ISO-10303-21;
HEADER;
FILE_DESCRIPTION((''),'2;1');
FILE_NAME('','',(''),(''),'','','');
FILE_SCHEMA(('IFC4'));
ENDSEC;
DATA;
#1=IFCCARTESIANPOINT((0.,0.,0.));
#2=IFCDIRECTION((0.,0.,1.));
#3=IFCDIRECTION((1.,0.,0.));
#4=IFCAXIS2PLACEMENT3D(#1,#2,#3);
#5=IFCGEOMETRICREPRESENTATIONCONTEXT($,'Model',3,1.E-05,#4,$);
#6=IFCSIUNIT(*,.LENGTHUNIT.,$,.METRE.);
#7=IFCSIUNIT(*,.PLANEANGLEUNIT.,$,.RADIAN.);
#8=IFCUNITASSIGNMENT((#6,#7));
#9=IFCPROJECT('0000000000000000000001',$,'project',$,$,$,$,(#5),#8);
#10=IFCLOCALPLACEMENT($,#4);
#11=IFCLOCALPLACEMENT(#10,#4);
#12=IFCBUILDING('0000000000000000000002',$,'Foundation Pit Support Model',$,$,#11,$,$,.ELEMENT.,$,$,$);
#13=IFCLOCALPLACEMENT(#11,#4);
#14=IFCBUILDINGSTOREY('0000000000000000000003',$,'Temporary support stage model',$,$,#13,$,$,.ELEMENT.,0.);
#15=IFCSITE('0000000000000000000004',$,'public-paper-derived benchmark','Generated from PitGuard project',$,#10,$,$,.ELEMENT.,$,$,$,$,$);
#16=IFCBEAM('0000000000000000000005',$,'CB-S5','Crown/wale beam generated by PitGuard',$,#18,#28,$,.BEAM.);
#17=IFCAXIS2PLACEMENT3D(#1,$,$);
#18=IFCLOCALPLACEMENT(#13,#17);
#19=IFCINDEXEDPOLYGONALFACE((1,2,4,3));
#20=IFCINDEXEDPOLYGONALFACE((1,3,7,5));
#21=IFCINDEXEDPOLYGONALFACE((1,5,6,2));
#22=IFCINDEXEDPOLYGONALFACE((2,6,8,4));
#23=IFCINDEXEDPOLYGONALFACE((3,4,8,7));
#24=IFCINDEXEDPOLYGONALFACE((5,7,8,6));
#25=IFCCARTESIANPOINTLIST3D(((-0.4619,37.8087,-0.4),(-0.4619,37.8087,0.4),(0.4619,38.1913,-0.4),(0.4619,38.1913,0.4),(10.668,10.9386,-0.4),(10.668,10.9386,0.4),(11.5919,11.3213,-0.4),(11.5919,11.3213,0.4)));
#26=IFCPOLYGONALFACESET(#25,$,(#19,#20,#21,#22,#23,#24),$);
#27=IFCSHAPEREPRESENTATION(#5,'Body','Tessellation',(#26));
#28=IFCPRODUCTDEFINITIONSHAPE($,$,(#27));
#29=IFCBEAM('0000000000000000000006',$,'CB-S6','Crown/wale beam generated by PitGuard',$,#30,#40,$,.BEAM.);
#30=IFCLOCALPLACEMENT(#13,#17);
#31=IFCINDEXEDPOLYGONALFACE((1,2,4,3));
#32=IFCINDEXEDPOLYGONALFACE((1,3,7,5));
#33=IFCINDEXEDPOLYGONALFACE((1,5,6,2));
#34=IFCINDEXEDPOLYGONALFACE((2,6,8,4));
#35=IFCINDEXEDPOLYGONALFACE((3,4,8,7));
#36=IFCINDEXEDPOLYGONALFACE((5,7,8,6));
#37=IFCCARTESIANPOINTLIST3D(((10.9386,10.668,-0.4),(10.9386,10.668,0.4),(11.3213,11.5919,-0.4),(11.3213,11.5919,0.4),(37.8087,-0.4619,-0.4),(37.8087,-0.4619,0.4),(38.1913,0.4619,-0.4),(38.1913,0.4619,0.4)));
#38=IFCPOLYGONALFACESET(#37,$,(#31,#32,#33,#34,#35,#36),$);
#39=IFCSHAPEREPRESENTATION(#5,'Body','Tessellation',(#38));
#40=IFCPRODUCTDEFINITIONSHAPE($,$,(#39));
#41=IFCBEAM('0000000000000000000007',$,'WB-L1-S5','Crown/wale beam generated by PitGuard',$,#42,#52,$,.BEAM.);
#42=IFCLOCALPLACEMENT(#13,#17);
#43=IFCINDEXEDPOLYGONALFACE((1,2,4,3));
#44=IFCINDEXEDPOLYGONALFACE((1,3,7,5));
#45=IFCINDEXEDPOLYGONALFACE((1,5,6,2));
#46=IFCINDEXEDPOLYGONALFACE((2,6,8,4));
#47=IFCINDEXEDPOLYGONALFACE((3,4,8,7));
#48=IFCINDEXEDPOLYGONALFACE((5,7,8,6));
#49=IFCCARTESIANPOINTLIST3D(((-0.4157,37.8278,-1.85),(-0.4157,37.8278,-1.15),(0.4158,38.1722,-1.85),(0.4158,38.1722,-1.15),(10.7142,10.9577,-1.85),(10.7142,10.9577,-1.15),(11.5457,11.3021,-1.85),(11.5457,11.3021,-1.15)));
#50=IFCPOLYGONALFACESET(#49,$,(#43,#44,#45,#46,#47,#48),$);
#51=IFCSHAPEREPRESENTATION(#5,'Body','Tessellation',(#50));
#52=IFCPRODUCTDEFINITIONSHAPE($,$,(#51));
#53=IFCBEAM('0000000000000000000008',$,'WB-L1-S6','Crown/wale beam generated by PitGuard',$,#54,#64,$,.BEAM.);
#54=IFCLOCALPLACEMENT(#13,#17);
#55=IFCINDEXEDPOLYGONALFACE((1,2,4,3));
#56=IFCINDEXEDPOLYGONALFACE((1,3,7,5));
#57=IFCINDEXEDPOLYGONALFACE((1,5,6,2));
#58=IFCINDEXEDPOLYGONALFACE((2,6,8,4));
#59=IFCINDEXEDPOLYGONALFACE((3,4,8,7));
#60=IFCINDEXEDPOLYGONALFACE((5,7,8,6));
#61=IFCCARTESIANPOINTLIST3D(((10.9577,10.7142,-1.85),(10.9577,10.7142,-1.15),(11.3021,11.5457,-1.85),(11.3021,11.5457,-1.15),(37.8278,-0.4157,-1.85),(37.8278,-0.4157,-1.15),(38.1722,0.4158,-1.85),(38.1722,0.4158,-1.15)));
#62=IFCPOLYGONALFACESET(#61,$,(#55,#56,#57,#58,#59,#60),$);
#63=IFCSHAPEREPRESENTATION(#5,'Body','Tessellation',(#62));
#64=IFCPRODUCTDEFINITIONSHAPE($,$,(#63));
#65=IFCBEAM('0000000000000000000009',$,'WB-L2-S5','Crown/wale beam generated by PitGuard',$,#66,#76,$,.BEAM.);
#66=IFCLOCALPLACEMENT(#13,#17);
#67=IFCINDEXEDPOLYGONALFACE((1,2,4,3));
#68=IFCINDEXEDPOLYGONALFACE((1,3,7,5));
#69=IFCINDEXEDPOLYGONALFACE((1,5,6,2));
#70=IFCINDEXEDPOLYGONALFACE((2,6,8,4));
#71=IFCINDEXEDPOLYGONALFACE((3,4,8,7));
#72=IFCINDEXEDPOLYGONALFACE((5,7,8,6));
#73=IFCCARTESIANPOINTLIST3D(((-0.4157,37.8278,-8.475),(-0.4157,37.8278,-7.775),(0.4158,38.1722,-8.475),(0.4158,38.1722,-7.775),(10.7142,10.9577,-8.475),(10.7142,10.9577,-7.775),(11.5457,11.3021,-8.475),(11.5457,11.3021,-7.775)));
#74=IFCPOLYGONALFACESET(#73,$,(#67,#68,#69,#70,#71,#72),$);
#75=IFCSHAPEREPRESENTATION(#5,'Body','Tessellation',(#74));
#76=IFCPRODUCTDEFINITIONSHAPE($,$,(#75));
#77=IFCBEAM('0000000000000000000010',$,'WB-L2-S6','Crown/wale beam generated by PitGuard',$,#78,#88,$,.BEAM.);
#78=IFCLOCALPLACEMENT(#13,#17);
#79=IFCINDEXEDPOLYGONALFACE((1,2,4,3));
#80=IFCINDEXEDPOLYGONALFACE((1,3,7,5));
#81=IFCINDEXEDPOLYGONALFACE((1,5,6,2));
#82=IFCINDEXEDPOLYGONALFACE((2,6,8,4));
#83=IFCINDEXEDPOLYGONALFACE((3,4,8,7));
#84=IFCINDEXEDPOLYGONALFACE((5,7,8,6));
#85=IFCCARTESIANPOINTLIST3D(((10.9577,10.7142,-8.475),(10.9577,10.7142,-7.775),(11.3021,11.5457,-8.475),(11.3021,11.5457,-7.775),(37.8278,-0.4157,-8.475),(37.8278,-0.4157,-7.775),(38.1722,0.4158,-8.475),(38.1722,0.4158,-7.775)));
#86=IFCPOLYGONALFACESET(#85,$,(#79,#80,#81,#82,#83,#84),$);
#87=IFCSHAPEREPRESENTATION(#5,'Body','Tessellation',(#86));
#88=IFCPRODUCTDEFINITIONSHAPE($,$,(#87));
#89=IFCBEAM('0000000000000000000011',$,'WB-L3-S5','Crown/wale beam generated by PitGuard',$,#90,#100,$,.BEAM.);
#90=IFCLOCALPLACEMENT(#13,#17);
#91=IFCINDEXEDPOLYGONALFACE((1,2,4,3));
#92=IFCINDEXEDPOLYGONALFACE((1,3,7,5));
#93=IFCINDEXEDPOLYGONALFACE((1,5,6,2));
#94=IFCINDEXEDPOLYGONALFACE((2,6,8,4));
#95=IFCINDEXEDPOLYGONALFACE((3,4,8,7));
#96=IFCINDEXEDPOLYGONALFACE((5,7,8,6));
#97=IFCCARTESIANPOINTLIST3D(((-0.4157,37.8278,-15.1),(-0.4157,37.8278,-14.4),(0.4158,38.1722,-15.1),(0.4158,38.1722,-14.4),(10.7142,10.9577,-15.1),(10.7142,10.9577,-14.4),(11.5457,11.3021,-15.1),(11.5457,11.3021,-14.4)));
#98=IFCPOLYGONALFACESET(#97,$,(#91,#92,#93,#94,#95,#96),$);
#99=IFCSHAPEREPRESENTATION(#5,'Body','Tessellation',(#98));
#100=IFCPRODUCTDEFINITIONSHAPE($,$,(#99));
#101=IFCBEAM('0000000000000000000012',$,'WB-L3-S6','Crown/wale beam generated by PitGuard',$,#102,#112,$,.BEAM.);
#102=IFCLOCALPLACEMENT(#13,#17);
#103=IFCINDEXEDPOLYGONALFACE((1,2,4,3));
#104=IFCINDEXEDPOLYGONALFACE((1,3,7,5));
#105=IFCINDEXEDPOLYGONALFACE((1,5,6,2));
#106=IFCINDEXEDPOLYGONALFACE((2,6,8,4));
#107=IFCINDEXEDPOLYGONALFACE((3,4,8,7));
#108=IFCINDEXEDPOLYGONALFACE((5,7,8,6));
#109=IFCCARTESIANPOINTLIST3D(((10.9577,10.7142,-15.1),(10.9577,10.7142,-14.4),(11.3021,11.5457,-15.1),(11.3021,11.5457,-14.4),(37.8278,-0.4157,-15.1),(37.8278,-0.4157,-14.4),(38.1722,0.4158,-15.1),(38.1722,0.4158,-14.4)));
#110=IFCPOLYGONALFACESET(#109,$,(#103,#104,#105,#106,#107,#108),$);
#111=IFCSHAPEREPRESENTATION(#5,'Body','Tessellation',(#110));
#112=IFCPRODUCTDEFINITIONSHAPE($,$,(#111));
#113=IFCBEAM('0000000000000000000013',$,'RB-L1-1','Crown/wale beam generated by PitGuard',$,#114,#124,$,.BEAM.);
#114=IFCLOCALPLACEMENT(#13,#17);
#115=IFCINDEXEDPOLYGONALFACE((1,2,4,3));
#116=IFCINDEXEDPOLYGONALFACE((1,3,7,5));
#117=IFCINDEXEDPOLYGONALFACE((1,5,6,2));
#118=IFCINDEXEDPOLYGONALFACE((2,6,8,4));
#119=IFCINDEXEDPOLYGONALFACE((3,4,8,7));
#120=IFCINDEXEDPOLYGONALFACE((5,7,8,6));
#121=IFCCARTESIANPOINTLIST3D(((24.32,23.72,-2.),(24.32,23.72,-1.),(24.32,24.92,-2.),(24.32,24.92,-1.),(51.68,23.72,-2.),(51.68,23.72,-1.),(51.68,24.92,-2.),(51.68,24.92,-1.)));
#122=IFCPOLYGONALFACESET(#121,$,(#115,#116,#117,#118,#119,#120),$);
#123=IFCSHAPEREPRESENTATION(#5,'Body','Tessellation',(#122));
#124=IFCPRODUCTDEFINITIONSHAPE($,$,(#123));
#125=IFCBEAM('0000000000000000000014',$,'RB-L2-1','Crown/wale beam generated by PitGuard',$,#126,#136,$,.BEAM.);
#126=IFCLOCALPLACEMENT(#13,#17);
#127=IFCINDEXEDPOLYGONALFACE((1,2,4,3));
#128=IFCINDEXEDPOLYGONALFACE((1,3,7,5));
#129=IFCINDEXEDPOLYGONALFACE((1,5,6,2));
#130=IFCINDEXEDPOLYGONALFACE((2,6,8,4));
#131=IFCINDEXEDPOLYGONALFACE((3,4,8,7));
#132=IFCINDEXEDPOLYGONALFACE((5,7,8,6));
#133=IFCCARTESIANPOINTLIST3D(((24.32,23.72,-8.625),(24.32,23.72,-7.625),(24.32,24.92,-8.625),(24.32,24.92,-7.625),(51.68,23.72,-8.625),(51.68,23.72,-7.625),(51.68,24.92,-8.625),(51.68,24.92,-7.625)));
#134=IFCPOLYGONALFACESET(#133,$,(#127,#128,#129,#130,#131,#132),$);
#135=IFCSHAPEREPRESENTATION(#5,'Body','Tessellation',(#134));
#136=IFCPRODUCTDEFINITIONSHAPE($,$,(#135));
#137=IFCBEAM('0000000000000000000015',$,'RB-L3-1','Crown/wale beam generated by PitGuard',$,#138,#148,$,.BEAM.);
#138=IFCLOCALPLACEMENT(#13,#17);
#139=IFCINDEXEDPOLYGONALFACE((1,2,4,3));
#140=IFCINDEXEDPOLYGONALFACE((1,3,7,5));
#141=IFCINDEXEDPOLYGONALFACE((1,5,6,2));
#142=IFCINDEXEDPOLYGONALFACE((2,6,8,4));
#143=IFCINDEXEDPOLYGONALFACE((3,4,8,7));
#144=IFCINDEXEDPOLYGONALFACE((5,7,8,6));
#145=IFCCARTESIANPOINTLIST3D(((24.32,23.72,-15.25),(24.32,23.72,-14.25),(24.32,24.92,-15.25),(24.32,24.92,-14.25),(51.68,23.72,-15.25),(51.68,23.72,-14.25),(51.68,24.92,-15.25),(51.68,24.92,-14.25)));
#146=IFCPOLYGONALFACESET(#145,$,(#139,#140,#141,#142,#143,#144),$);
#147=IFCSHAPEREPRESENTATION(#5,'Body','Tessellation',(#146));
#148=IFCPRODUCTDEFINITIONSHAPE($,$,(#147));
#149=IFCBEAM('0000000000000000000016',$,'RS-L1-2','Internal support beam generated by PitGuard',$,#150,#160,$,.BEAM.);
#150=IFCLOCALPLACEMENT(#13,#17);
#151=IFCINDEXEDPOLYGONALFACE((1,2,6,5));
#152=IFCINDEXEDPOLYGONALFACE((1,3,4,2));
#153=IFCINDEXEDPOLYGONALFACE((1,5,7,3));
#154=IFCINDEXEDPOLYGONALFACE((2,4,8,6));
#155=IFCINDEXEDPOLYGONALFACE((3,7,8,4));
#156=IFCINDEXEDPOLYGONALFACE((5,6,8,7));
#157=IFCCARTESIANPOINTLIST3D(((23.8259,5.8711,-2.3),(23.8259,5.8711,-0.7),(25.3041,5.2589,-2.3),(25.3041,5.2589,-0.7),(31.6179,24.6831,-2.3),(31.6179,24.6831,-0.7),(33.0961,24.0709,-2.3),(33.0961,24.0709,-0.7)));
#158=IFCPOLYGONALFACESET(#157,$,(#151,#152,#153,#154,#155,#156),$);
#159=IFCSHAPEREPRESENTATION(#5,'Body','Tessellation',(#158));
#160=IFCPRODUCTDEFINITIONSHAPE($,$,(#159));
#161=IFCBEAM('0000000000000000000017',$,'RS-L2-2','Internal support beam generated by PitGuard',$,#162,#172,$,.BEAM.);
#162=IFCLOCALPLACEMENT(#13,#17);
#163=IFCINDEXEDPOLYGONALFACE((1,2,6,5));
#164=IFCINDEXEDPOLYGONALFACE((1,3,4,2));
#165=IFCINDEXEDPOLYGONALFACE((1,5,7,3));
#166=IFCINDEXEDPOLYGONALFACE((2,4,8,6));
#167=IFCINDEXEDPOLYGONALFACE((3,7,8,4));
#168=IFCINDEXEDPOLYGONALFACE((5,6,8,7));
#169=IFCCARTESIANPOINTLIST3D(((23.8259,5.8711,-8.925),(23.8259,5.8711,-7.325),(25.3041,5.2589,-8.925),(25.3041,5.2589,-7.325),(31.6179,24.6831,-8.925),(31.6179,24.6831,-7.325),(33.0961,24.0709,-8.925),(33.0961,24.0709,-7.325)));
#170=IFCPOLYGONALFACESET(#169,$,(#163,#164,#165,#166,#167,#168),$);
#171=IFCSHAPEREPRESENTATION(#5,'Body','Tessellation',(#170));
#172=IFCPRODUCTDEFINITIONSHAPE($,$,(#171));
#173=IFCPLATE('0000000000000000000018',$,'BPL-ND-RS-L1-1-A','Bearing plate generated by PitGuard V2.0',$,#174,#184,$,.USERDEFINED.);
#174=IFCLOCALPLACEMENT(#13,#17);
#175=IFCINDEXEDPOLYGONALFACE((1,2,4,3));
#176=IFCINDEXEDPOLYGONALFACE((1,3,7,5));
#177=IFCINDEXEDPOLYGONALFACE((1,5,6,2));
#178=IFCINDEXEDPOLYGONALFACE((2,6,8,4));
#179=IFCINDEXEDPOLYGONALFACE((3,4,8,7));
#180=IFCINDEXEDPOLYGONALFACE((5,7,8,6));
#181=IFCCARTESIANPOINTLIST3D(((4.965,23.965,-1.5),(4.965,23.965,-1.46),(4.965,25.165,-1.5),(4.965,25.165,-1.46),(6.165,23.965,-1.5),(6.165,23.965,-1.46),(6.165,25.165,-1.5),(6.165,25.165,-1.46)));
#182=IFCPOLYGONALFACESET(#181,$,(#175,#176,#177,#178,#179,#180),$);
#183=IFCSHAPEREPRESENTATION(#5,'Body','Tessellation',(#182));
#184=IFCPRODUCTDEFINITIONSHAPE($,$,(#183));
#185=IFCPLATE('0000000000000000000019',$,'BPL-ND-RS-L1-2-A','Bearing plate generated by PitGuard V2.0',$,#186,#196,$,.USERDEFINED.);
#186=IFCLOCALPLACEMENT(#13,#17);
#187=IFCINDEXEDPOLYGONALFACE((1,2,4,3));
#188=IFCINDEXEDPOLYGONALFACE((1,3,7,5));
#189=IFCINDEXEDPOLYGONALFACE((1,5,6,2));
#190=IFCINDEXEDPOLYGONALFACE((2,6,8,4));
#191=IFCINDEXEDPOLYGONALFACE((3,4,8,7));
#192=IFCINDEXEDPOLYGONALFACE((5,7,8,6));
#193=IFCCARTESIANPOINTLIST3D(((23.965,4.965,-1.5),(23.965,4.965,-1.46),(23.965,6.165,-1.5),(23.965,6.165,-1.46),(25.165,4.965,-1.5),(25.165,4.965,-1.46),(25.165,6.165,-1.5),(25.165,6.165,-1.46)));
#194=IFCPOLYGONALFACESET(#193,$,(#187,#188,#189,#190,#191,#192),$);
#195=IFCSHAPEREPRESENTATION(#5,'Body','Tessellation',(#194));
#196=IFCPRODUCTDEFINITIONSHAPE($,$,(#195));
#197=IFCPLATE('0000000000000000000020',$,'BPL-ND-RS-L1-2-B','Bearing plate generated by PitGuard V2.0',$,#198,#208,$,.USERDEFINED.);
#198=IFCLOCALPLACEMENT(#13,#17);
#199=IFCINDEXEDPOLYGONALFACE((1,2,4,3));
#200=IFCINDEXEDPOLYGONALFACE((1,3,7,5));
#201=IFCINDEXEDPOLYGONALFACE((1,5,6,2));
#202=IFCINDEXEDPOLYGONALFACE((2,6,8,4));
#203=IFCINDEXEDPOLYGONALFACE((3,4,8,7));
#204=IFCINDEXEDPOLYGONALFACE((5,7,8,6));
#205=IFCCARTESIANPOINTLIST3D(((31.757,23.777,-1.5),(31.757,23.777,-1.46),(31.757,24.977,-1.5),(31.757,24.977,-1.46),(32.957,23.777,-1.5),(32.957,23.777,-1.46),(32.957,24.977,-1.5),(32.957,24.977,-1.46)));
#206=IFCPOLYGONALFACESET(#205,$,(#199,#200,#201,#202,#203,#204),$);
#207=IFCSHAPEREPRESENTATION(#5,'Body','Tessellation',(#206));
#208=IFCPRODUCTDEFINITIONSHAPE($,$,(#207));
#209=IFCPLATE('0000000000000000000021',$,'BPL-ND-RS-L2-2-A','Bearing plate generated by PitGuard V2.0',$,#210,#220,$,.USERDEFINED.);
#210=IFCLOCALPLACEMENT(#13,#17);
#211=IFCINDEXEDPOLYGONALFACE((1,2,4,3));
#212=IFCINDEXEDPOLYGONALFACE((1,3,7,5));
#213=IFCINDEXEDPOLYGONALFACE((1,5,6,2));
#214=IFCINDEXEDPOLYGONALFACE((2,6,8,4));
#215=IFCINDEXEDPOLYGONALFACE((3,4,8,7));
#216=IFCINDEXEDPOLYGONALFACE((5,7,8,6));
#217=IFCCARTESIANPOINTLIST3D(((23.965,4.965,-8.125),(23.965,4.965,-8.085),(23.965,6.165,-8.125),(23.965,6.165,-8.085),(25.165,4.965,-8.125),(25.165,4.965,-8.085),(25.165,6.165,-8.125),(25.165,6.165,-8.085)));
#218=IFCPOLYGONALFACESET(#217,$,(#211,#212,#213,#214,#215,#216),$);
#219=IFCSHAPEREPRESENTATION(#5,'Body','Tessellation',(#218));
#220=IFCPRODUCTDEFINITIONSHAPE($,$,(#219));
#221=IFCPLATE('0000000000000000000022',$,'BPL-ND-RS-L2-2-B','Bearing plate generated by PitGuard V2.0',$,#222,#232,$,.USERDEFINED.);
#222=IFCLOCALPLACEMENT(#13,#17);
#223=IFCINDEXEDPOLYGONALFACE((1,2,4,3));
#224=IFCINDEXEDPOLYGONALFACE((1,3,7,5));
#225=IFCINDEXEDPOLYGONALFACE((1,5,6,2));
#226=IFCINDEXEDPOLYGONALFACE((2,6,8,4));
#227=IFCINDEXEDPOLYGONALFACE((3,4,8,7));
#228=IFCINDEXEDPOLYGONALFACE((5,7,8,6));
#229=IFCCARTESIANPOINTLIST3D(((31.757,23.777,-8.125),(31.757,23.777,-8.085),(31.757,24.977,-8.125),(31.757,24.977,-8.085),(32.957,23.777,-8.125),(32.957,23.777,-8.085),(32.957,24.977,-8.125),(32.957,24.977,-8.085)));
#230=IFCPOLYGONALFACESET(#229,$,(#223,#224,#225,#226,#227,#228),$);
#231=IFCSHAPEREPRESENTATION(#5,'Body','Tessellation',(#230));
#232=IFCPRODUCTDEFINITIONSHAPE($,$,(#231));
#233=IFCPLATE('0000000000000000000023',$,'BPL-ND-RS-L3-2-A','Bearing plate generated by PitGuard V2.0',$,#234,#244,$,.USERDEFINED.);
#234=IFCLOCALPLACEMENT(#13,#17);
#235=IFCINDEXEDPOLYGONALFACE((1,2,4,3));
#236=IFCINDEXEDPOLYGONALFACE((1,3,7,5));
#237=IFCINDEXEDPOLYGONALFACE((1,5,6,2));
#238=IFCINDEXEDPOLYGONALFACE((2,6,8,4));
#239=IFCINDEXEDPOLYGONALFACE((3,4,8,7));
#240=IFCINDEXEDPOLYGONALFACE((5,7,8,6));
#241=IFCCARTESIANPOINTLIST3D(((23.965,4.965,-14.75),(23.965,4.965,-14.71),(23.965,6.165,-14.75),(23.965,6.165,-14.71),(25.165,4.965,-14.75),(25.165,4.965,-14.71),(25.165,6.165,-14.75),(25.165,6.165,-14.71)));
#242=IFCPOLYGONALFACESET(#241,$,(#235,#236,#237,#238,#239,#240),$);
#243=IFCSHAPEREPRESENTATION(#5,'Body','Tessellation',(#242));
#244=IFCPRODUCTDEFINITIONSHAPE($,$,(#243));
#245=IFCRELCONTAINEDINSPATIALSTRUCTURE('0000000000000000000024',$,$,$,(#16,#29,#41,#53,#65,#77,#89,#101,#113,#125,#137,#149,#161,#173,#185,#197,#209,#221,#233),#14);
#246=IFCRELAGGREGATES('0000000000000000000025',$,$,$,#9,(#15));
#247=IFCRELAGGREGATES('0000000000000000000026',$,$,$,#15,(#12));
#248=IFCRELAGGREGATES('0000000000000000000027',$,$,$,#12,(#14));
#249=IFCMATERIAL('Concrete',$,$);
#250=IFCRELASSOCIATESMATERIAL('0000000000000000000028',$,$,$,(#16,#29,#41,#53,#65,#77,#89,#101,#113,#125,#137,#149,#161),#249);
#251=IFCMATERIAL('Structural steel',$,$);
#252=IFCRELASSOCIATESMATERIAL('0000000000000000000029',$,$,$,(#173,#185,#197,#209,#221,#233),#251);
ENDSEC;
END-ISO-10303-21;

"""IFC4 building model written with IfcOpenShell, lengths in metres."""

from ifc_helpers import new_model, si_unit, frame, origin_with_axes, origin_2d, place, context, project, spatial, rectangle, extrude, material, element, save


model = new_model("IFC4")

# Units and contexts
model_context = context("Model", 3, precision=1e-05, world=origin_with_axes())
ifc_project = project(units=[si_unit("LENGTHUNIT", "METRE"), si_unit("PLANEANGLEUNIT", "RADIAN")], contexts=[model_context])

# Site, building, storey
site_placement = place(None, origin_with_axes())
site = spatial("IfcSite", under=ifc_project, at=site_placement, Name="public-paper-derived benchmark", Description="Generated from PitGuard project", CompositionType="ELEMENT")
building_placement = place(site_placement, origin_with_axes())
building = spatial("IfcBuilding", under=site, at=building_placement, Name="Foundation Pit Support Model", CompositionType="ELEMENT")
storey_placement = place(building_placement, origin_with_axes())
storey = spatial("IfcBuildingStorey", under=building, at=storey_placement, Name="Temporary support stage model", CompositionType="ELEMENT", Elevation=0.0)

# Beams
ifc_material_1 = material(Name="Concrete")
for number, where, z_axis, x_axis, name in (
    (1, (5.565, 24.565, -0.4), (0.0, 0.0, 1.0), (0.382683, -0.92388, 0.0), "CB-S5"),
    (2, (24.565, 5.565, -0.4), (0.0, 0.0, 1.0), (0.92388, -0.382683, 0.0), "CB-S6"),
):
    element("IfcBeam", number, at=place(storey_placement, frame(where, z_axis=z_axis, x_axis=x_axis)), inside=storey, material=ifc_material_1, Name=name, Description="Crown/wale beam generated by PitGuard", PredefinedType="BEAM", context=model_context, shape_type="SweptSolid", body=[
        extrude(rectangle(XDim=29.0839, YDim=1.0, at=origin_2d()), origin_with_axes(), (0.0, 0.0, 1.0), 0.8),
    ])
for number, where, z_axis, x_axis, name in (
    (3, (5.565, 24.565, -1.85), (0.0, 0.0, 1.0), (0.382683, -0.92388, 0.0), "WB-L1-S5"),
    (4, (24.565, 5.565, -1.85), (0.0, 0.0, 1.0), (0.92388, -0.382683, 0.0), "WB-L1-S6"),
    (5, (5.565, 24.565, -8.475), (0.0, 0.0, 1.0), (0.382683, -0.92388, 0.0), "WB-L2-S5"),
    (6, (24.565, 5.565, -8.475), (0.0, 0.0, 1.0), (0.92388, -0.382683, 0.0), "WB-L2-S6"),
    (7, (5.565, 24.565, -15.1), (0.0, 0.0, 1.0), (0.382683, -0.92388, 0.0), "WB-L3-S5"),
    (8, (24.565, 5.565, -15.1), (0.0, 0.0, 1.0), (0.92388, -0.382683, 0.0), "WB-L3-S6"),
):
    element("IfcBeam", number, at=place(storey_placement, frame(where, z_axis=z_axis, x_axis=x_axis)), inside=storey, material=ifc_material_1, Name=name, Description="Crown/wale beam generated by PitGuard", PredefinedType="BEAM", context=model_context, shape_type="SweptSolid", body=[
        extrude(rectangle(XDim=29.0839, YDim=0.9, at=origin_2d()), origin_with_axes(), (0.0, 0.0, 1.0), 0.7),
    ])
for number, where, z_axis, x_axis, name in (
    (9, (38.0, 24.32, -2.0), (0.0, 0.0, 1.0), (1.0, 0.0, 0.0), "RB-L1-1"),
    (10, (38.0, 24.32, -8.625), (0.0, 0.0, 1.0), (1.0, 0.0, 0.0), "RB-L2-1"),
    (11, (38.0, 24.32, -15.25), (0.0, 0.0, 1.0), (1.0, 0.0, 0.0), "RB-L3-1"),
):
    element("IfcBeam", number, at=place(storey_placement, frame(where, z_axis=z_axis, x_axis=x_axis)), inside=storey, material=ifc_material_1, Name=name, Description="Crown/wale beam generated by PitGuard", PredefinedType="BEAM", context=model_context, shape_type="SweptSolid", body=[
        extrude(rectangle(XDim=27.36, YDim=1.2, at=origin_2d()), origin_with_axes(), (0.0, 0.0, 1.0), 1.0),
    ])
for number, where, z_axis, x_axis, name in (
    (12, (28.461, 14.971, -2.3), (0.0, 0.0, 1.0), (0.382676, 0.923883, 0.0), "RS-L1-2"),
    (13, (28.461, 14.971, -8.925), (0.0, 0.0, 1.0), (0.382676, 0.923883, 0.0), "RS-L2-2"),
):
    element("IfcBeam", number, at=place(storey_placement, frame(where, z_axis=z_axis, x_axis=x_axis)), inside=storey, material=ifc_material_1, Name=name, Description="Internal support beam generated by PitGuard", PredefinedType="BEAM", context=model_context, shape_type="SweptSolid", body=[
        extrude(rectangle(XDim=20.3619, YDim=1.6, at=origin_2d()), origin_with_axes(), (0.0, 0.0, 1.0), 1.6),
    ])

# Plates
ifc_material_2 = material(Name="Structural steel")
for number, where, z_axis, x_axis, name in (
    (14, (5.565, 24.565, -1.5), (0.0, 0.0, 1.0), (1.0, 0.0, 0.0), "BPL-ND-RS-L1-1-A"),
    (15, (24.565, 5.565, -1.5), (0.0, 0.0, 1.0), (1.0, 0.0, 0.0), "BPL-ND-RS-L1-2-A"),
    (16, (32.357, 24.377, -1.5), (0.0, 0.0, 1.0), (1.0, 0.0, 0.0), "BPL-ND-RS-L1-2-B"),
    (17, (24.565, 5.565, -8.125), (0.0, 0.0, 1.0), (1.0, 0.0, 0.0), "BPL-ND-RS-L2-2-A"),
    (18, (32.357, 24.377, -8.125), (0.0, 0.0, 1.0), (1.0, 0.0, 0.0), "BPL-ND-RS-L2-2-B"),
    (19, (24.565, 5.565, -14.75), (0.0, 0.0, 1.0), (1.0, 0.0, 0.0), "BPL-ND-RS-L3-2-A"),
):
    element("IfcPlate", number, at=place(storey_placement, frame(where, z_axis=z_axis, x_axis=x_axis)), inside=storey, material=ifc_material_2, Name=name, Description="Bearing plate generated by PitGuard V2.0", PredefinedType="USERDEFINED", context=model_context, shape_type="SweptSolid", body=[
        extrude(rectangle(XDim=1.2, YDim=1.2, at=origin_2d()), origin_with_axes(), (0.0, 0.0, 1.0), 0.04),
    ])

save(model, "model.ifc")
